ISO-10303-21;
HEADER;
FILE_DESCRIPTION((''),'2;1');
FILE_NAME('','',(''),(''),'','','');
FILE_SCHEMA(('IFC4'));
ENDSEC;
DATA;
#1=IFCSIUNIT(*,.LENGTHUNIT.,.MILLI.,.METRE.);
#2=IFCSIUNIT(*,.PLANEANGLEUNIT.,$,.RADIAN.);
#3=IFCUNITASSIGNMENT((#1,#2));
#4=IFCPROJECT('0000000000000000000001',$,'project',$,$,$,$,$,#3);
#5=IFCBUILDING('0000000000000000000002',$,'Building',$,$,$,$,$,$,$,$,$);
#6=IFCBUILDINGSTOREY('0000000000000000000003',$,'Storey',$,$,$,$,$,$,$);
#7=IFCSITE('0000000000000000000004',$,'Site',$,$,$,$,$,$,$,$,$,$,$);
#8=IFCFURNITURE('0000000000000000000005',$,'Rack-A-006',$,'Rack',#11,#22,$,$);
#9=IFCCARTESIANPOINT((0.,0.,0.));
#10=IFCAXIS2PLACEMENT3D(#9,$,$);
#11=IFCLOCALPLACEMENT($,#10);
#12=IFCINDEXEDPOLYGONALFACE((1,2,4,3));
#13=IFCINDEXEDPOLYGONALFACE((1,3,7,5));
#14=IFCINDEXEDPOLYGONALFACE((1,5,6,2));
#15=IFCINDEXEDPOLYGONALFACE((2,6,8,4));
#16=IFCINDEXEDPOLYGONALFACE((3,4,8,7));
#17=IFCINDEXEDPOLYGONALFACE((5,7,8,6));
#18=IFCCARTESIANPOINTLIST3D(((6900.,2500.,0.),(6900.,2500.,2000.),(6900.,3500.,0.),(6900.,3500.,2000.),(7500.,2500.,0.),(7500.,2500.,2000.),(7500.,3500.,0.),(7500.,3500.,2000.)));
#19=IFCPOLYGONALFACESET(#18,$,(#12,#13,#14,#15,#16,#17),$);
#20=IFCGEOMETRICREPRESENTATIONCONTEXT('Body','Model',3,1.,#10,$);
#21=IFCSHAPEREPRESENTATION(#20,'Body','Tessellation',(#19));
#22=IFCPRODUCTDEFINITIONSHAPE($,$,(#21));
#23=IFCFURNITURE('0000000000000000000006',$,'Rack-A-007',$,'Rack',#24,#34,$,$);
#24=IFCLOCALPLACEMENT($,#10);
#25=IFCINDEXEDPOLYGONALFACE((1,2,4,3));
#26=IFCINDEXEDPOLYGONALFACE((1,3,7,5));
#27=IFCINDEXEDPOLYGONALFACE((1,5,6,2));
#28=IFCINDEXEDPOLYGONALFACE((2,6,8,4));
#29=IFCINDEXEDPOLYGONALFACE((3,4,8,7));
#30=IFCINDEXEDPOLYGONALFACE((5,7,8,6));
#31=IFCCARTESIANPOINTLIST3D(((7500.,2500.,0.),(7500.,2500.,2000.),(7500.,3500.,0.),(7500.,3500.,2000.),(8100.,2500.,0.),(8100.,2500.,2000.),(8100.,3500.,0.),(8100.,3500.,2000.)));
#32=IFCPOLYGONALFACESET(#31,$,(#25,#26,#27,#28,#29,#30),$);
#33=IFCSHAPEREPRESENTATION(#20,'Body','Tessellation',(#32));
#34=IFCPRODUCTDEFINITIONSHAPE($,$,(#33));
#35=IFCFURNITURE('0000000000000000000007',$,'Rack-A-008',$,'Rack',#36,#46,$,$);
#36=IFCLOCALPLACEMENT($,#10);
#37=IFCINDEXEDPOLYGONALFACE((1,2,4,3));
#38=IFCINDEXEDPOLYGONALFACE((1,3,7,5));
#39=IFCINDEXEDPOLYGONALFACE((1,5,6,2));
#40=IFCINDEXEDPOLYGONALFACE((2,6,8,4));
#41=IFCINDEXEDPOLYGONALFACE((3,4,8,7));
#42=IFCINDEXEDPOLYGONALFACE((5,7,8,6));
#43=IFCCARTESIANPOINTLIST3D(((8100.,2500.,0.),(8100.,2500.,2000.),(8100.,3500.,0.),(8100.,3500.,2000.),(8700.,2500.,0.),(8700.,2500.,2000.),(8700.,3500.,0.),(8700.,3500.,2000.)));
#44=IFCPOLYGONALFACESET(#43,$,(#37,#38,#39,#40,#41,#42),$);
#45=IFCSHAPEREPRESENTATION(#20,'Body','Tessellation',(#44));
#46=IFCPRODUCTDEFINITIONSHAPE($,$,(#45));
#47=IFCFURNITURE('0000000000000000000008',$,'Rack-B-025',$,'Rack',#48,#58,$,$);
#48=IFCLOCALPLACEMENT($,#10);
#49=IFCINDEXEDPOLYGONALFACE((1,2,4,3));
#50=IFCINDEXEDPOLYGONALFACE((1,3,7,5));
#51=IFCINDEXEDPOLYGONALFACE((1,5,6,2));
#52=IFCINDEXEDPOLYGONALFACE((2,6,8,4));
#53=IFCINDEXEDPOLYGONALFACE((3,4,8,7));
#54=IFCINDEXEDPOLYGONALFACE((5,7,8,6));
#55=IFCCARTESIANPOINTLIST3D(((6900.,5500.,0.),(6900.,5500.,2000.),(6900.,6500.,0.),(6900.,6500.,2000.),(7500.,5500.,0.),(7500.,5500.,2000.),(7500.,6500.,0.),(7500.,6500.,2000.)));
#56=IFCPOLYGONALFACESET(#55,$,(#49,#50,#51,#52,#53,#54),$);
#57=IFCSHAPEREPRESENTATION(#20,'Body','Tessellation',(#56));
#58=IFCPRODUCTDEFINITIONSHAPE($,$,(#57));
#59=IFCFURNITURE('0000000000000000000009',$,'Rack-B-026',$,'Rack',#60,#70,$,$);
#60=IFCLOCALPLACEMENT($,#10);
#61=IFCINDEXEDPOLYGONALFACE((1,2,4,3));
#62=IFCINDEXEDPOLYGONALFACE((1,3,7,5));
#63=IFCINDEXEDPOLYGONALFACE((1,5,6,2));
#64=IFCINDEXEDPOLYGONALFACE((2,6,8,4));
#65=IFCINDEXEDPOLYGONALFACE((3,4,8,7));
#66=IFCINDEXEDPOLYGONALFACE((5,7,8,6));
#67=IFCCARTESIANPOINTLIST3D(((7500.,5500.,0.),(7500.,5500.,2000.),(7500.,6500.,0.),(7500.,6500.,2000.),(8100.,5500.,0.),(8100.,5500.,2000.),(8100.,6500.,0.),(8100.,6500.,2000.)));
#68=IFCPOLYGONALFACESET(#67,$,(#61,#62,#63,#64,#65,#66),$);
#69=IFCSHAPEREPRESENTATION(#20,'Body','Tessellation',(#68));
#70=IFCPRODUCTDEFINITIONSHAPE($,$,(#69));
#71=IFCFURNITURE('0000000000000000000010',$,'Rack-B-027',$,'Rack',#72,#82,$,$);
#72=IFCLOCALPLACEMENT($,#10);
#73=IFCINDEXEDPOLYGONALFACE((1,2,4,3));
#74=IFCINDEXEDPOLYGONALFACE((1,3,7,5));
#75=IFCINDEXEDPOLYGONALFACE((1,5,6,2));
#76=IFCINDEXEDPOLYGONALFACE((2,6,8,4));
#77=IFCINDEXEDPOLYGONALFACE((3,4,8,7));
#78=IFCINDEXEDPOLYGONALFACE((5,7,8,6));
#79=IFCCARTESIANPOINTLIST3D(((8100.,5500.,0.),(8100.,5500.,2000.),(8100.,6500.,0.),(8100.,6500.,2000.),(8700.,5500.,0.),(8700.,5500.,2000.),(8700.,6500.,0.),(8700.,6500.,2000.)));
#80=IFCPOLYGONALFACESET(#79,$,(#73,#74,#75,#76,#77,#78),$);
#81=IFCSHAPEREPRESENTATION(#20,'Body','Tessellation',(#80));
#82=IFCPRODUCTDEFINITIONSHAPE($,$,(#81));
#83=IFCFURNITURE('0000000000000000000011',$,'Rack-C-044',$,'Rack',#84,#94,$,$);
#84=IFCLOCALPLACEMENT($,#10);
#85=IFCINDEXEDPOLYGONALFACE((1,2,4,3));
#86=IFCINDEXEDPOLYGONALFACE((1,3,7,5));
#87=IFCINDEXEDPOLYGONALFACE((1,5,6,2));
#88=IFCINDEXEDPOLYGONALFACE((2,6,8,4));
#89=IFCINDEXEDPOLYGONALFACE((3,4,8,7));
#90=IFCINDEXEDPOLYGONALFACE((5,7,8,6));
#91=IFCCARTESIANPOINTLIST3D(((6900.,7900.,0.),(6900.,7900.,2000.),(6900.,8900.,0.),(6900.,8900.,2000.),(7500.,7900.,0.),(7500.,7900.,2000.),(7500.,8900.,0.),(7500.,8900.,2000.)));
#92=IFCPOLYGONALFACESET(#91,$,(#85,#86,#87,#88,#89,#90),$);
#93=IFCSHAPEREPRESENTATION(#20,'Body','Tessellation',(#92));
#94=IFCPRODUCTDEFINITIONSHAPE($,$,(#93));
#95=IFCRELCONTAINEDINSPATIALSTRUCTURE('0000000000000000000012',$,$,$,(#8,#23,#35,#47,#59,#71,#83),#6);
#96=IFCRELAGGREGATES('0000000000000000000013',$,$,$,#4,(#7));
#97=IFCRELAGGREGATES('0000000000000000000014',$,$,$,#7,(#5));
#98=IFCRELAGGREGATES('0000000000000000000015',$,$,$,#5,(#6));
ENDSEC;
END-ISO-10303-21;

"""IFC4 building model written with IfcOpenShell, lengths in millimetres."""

from ifc_helpers import new_model, si_unit, frame, origin, place, context, project, spatial, rectangle, extrude, element, save


model = new_model("IFC4")

# Units and contexts
model_context = context("Model", 3, precision=1.0, world=origin(), identifier="Body")
ifc_project = project(units=[si_unit("LENGTHUNIT", "METRE", prefix="MILLI"), si_unit("PLANEANGLEUNIT", "RADIAN")])

# Site, building, storey
site = spatial("IfcSite", under=ifc_project, Name="Site")
building = spatial("IfcBuilding", under=site, Name="Building")
storey = spatial("IfcBuildingStorey", under=building, Name="Storey")

# Furniture
for number, where, z_axis, x_axis, name in (
    (1, (7200.0, 3000.0, 0.0), (0.0, 0.0, 1.0), (1.0, 0.0, 0.0), "Rack-A-006"),
    (2, (7800.0, 3000.0, 0.0), (0.0, 0.0, 1.0), (1.0, 0.0, 0.0), "Rack-A-007"),
    (3, (8400.0, 3000.0, 0.0), (0.0, 0.0, 1.0), (1.0, 0.0, 0.0), "Rack-A-008"),
    (4, (7200.0, 6000.0, 0.0), (0.0, 0.0, 1.0), (1.0, 0.0, 0.0), "Rack-B-025"),
    (5, (7800.0, 6000.0, 0.0), (0.0, 0.0, 1.0), (1.0, 0.0, 0.0), "Rack-B-026"),
    (6, (8400.0, 6000.0, 0.0), (0.0, 0.0, 1.0), (1.0, 0.0, 0.0), "Rack-B-027"),
    (7, (7200.0, 8400.0, 0.0), (0.0, 0.0, 1.0), (1.0, 0.0, 0.0), "Rack-C-044"),
):
    element("IfcFurniture", number, at=place(None, frame(where, z_axis=z_axis, x_axis=x_axis)), inside=storey, Name=name, ObjectType="Rack", context=model_context, shape_type="SweptSolid", body=[
        extrude(rectangle(XDim=600.0, YDim=1000.0), origin(), (0.0, 0.0, 1.0), 2000.0),
    ])

save(model, "model.ifc")
